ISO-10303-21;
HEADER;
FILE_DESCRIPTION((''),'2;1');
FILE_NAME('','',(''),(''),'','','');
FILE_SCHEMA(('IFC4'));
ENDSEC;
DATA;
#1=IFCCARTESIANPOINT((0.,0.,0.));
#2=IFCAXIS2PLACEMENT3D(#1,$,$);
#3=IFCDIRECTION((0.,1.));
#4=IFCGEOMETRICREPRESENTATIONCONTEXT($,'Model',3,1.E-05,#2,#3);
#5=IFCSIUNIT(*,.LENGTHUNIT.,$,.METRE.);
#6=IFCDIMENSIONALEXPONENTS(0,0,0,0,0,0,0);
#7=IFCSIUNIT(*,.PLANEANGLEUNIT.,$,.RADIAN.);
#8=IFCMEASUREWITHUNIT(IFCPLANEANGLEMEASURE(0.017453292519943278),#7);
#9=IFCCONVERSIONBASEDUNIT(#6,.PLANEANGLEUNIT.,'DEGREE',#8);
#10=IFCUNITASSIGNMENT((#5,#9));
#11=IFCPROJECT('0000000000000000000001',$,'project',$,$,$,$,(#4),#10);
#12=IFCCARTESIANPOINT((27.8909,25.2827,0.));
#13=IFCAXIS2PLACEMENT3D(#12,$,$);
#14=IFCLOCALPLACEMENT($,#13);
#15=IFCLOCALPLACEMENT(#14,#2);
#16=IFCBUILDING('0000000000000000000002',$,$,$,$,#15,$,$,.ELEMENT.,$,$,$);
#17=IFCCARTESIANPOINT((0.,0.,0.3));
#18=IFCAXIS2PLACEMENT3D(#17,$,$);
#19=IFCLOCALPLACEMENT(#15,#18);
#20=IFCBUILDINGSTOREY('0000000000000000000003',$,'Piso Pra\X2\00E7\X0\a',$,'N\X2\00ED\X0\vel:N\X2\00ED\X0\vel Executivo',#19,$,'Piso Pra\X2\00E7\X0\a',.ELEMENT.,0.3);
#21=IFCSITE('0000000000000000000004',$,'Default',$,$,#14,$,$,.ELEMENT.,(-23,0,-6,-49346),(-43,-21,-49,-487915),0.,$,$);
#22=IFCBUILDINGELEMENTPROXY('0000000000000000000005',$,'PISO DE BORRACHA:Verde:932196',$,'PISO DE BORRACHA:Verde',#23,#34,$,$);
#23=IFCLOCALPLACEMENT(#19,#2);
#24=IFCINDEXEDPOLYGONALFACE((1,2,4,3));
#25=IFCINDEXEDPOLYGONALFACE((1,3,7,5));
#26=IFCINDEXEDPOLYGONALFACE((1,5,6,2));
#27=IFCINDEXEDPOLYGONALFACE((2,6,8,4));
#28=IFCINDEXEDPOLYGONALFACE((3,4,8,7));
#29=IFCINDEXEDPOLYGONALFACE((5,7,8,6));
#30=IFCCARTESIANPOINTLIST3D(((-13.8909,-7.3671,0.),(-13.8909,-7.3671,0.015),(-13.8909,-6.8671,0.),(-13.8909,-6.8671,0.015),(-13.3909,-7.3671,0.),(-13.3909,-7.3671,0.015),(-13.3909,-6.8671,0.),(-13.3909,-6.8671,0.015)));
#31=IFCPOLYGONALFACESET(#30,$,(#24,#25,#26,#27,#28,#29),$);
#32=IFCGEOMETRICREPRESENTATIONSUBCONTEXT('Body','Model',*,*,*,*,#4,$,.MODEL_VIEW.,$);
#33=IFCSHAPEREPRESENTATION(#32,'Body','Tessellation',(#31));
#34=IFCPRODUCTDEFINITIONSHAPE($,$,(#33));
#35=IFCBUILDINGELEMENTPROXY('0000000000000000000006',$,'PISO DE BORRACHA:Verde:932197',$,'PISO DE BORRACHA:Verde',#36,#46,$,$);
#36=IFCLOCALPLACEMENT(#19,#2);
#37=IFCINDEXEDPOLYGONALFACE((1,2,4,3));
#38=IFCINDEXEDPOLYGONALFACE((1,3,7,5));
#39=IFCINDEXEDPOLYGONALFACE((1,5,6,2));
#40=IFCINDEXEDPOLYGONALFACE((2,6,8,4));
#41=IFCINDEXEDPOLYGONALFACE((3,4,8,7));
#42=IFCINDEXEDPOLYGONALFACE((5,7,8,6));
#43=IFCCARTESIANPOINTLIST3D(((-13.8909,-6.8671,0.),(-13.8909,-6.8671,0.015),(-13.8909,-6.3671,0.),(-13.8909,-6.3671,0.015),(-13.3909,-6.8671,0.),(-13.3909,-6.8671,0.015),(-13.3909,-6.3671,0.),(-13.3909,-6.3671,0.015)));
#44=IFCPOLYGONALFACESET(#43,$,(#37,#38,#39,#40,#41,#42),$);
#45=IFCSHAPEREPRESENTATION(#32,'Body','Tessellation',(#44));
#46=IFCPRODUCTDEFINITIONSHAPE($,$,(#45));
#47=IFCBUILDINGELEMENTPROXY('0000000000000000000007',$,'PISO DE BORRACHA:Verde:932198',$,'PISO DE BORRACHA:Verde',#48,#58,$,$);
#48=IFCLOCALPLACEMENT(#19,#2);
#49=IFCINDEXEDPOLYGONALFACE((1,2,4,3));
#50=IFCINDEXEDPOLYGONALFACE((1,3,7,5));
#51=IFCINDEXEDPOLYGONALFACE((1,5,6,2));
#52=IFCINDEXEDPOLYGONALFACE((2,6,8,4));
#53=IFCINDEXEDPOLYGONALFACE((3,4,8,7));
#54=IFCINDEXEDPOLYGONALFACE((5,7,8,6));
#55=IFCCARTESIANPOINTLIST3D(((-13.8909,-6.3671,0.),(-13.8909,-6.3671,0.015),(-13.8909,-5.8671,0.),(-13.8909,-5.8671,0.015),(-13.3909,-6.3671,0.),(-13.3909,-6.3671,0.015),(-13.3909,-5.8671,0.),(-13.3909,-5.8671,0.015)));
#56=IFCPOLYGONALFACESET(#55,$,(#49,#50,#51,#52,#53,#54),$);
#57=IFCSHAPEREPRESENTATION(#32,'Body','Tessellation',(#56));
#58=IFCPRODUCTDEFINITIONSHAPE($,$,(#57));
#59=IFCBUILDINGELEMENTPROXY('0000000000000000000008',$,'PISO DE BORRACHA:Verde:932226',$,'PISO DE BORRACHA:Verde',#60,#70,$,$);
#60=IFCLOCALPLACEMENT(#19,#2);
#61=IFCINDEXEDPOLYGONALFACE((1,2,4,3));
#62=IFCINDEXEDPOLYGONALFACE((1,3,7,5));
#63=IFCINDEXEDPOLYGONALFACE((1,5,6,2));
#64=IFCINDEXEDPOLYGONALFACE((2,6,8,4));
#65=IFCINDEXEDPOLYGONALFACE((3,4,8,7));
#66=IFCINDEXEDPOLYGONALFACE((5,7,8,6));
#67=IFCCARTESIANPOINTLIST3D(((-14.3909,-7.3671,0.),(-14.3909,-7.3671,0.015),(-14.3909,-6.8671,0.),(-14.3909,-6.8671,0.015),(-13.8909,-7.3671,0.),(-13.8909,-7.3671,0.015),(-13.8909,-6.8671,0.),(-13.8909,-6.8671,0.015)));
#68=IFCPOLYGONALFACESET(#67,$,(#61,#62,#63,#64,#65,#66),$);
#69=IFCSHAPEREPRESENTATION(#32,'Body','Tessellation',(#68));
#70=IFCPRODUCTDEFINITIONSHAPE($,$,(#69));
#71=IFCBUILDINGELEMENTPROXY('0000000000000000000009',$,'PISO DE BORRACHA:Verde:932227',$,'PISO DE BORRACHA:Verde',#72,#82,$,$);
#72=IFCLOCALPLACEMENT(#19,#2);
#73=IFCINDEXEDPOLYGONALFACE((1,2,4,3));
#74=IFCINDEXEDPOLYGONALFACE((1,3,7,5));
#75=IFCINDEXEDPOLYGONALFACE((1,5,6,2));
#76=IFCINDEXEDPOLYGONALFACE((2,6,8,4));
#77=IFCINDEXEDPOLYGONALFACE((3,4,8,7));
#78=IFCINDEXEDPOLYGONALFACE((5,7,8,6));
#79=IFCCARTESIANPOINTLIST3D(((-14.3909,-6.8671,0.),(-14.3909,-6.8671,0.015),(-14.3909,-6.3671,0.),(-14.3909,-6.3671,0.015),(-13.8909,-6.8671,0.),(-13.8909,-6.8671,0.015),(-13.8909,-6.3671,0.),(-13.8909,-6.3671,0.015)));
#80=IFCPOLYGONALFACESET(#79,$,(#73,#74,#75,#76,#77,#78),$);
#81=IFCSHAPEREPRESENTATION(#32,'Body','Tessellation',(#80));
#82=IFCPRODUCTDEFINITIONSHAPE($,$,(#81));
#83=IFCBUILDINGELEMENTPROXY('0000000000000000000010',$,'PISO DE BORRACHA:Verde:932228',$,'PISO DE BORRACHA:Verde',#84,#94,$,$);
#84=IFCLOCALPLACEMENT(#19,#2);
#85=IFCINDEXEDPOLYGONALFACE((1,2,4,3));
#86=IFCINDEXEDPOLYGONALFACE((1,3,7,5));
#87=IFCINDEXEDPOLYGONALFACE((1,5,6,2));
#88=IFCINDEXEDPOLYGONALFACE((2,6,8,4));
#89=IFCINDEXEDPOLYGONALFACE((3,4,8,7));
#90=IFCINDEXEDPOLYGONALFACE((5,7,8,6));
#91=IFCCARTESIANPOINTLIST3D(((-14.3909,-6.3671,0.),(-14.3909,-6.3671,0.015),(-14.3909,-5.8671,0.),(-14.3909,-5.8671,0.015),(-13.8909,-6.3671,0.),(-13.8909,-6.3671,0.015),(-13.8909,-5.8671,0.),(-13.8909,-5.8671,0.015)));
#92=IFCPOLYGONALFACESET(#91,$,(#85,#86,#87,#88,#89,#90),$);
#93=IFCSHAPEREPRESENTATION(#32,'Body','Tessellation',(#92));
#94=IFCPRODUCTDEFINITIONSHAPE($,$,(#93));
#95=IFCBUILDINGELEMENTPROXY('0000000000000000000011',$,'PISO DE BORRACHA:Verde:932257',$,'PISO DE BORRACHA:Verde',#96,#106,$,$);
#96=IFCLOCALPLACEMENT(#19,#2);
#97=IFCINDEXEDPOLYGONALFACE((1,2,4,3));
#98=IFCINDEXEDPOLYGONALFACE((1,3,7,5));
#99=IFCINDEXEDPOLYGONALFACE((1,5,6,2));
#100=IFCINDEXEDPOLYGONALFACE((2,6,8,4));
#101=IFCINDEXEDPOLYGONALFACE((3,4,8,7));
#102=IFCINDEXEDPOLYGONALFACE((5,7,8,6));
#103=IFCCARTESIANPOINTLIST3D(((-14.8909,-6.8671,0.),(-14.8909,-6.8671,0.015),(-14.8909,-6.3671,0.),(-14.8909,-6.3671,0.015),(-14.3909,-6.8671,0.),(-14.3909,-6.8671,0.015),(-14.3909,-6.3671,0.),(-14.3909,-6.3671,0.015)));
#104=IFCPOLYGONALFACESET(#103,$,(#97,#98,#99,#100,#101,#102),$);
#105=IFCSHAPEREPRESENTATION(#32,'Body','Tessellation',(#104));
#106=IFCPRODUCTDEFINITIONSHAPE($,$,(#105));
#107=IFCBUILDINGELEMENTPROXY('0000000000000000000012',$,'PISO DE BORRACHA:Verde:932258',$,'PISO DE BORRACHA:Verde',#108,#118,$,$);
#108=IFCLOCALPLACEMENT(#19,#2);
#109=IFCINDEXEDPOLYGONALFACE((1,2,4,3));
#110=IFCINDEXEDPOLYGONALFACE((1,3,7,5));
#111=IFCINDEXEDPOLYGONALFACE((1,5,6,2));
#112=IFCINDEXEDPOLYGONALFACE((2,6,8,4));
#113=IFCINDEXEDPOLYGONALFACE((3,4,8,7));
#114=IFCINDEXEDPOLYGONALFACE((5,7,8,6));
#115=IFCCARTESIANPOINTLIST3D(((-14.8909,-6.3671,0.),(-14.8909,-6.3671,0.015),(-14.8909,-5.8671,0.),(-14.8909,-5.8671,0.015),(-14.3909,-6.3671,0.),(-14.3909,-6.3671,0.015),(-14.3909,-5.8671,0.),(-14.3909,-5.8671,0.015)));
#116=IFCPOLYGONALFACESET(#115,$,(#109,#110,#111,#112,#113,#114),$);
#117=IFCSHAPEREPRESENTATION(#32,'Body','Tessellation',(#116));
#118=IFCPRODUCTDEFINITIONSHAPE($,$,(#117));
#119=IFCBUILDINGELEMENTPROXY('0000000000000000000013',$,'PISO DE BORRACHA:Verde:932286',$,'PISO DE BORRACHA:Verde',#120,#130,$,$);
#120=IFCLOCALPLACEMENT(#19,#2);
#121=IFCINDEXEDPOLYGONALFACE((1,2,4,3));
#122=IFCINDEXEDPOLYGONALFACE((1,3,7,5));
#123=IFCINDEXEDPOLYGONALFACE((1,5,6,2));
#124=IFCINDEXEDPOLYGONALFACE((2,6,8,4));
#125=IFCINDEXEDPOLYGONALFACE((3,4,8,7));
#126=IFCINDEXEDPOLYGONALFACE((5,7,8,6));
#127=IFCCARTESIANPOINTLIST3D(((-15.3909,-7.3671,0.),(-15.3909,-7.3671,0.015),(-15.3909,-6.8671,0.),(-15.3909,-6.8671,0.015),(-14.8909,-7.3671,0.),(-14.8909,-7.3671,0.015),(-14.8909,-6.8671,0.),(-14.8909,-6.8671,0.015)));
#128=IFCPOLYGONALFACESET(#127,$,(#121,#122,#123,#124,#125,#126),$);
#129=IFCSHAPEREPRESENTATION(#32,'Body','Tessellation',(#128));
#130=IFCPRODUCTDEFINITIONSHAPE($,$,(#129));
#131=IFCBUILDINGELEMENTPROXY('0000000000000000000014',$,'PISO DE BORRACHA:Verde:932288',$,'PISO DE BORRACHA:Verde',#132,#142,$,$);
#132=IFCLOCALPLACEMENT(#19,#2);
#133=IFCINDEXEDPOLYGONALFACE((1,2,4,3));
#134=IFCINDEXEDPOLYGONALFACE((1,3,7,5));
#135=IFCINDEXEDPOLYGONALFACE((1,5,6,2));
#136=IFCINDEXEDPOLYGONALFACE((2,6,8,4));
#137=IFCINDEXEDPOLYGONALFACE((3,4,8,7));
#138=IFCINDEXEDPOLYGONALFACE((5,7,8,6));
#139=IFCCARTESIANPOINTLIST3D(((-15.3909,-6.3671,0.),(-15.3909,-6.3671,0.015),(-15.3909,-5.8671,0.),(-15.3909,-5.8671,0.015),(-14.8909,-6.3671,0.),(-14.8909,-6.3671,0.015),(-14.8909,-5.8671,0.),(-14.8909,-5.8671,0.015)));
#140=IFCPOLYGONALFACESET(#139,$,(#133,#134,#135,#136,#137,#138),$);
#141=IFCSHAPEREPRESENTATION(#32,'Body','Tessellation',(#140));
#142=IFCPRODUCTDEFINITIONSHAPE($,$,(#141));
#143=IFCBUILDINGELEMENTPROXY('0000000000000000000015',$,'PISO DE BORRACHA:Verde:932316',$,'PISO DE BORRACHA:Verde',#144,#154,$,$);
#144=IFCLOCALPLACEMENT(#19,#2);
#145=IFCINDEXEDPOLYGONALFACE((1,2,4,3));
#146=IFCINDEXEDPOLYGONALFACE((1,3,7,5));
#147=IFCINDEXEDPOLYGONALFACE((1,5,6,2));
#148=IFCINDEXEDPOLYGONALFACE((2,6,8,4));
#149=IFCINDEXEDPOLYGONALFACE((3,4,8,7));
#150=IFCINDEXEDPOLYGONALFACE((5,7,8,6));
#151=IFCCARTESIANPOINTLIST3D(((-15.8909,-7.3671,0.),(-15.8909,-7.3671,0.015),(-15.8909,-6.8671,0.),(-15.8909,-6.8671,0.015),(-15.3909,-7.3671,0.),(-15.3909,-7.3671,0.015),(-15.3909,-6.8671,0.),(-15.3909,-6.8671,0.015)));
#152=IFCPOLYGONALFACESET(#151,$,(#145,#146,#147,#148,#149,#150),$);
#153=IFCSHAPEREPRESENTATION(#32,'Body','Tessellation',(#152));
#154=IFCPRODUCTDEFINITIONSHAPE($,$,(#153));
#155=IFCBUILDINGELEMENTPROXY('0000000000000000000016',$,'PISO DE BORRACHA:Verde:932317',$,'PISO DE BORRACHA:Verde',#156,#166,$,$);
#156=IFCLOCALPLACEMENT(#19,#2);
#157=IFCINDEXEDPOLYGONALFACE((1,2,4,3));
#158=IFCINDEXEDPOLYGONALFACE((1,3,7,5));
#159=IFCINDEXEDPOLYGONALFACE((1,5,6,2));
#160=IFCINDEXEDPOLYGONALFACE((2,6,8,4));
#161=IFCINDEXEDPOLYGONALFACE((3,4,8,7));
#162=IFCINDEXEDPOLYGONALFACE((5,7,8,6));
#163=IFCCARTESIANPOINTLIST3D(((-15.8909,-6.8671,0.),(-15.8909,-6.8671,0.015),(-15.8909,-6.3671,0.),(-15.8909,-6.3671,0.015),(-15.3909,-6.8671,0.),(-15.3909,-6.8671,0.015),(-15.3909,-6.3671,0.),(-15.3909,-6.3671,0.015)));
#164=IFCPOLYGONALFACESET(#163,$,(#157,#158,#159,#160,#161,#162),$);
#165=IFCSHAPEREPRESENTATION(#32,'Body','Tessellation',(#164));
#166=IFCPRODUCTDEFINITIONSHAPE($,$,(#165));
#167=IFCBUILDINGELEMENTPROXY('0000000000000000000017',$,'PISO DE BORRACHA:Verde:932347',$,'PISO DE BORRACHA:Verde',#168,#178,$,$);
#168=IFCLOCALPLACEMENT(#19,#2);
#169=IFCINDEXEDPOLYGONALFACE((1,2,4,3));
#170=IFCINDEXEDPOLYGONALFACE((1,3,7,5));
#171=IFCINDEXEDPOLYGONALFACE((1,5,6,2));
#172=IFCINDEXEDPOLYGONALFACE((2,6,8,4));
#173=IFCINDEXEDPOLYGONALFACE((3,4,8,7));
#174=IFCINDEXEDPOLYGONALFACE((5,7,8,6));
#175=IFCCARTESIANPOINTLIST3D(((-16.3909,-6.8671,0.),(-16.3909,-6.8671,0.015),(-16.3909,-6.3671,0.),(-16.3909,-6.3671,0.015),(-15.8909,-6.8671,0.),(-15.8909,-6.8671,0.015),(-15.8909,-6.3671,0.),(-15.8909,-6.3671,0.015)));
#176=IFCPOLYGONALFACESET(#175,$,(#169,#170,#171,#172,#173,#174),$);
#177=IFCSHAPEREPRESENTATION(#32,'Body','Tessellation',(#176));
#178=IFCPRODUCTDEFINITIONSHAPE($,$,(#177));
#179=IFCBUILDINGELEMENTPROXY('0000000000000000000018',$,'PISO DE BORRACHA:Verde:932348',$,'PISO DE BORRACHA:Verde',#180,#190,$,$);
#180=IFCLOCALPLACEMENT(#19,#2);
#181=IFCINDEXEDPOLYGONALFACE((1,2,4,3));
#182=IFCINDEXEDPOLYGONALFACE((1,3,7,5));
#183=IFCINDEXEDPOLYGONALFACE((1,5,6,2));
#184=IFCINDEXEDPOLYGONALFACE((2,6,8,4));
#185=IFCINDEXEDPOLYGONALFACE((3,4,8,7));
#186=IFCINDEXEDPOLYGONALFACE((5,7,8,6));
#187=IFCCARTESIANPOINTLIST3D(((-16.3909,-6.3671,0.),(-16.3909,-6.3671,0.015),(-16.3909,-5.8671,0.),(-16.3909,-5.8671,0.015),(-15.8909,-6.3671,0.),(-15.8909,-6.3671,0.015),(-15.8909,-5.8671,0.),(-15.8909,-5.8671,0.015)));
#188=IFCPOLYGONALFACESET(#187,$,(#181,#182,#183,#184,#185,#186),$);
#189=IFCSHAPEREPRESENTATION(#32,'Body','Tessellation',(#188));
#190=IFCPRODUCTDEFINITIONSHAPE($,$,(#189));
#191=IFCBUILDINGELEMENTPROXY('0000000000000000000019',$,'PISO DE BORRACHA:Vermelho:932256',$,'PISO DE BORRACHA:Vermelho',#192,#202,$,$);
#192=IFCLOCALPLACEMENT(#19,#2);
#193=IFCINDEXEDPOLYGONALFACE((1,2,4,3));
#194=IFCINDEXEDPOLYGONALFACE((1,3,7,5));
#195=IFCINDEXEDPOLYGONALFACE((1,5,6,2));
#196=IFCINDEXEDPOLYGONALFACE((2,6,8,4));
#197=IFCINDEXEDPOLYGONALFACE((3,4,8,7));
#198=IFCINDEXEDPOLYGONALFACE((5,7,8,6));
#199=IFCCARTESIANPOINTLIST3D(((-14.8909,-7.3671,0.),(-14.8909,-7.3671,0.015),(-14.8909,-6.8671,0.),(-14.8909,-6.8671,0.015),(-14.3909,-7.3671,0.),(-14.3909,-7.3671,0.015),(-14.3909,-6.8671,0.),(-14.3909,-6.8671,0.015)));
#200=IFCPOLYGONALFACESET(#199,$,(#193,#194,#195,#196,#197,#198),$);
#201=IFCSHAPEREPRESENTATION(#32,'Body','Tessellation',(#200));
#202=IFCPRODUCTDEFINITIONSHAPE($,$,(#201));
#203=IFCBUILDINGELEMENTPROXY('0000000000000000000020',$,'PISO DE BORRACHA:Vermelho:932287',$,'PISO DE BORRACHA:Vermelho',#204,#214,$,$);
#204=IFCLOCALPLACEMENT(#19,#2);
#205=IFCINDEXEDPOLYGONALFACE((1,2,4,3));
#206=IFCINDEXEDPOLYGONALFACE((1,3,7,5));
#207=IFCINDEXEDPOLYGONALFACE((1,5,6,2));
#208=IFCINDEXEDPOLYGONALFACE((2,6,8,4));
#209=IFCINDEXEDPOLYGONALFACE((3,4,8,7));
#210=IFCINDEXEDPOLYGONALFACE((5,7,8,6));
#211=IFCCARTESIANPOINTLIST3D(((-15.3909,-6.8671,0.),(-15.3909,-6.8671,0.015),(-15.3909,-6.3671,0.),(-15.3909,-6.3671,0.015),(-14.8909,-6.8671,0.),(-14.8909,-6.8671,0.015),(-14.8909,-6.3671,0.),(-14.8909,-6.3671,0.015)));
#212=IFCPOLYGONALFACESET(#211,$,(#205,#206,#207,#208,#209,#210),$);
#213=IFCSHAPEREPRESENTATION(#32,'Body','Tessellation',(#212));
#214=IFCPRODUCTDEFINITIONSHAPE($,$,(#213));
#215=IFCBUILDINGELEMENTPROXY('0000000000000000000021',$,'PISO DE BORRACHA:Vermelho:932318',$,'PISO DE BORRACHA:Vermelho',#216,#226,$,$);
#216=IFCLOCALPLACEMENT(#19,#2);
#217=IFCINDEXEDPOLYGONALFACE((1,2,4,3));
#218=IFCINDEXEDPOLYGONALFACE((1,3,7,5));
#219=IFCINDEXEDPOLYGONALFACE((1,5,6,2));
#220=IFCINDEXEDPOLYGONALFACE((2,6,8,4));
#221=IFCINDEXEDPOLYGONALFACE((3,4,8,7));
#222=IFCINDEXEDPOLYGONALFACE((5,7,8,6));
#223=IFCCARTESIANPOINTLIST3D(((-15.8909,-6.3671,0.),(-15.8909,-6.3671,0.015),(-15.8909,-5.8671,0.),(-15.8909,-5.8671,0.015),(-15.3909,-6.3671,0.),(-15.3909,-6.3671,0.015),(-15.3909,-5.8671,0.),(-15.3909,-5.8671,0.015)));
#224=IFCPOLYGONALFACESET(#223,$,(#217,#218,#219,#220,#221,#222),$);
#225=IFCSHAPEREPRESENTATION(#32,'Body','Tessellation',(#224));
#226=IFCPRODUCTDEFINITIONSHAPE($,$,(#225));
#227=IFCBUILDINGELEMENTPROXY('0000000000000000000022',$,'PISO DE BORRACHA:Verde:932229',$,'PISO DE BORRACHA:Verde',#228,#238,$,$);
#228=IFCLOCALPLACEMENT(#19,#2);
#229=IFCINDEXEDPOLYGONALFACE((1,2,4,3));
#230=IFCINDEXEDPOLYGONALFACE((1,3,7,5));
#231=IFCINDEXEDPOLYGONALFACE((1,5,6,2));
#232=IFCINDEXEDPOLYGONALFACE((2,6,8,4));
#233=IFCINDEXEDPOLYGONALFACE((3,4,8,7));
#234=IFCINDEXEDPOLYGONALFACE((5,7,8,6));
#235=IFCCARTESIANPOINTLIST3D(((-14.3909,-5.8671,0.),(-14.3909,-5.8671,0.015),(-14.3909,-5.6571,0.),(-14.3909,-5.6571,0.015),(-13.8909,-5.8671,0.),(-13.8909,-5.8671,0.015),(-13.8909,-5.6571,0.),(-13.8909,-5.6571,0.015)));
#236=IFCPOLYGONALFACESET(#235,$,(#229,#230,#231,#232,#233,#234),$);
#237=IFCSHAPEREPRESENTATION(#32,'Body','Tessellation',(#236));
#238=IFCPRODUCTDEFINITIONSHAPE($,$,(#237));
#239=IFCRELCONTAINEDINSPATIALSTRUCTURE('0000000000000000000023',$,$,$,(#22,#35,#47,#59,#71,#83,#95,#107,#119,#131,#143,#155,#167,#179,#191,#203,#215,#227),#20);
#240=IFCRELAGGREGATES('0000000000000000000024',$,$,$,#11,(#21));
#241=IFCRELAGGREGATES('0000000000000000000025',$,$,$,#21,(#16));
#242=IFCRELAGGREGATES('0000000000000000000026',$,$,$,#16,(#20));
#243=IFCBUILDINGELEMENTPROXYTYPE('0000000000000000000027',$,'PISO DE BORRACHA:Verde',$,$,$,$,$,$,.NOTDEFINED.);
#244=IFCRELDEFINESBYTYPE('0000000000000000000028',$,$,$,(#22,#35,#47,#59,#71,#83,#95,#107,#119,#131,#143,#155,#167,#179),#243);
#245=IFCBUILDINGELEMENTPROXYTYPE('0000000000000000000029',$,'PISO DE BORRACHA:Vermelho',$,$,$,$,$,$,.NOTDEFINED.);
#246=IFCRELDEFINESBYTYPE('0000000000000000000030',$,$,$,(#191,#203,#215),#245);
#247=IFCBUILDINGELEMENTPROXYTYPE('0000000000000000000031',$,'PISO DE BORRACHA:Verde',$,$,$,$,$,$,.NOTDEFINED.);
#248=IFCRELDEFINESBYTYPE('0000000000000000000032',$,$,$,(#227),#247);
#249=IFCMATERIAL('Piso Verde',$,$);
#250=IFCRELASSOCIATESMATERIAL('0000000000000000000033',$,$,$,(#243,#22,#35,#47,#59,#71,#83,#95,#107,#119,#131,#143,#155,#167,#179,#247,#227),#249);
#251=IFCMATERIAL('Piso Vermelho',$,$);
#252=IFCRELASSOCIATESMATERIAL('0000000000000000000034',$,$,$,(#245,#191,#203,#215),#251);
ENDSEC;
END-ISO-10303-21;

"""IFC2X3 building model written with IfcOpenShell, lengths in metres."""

from ifc_helpers import new_model, entity, si_unit, converted_unit, direction, frame, frame_2d, origin, origin_2d_with_axis, place, context, subcontext, project, spatial, rectangle, extrude, source, transform, mapped, material, type_object, type_shapes, element, save


model = new_model("IFC2X3")

# Units and contexts
model_context = context("Model", 3, precision=1e-05, world=origin(), true_north=direction((0.0, 1.0)))
body_context = subcontext(model_context, "Body", "Model", "MODEL_VIEW")
ifc_project = project(units=[si_unit("LENGTHUNIT", "METRE"), converted_unit("PLANEANGLEUNIT", "DEGREE", entity("IfcPlaneAngleMeasure", 0.017453292519943278), si_unit("PLANEANGLEUNIT", "RADIAN"), dimensions=[0, 0, 0, 0, 0, 0, 0])], contexts=[model_context])

# Site, building, storey
site_placement = place(None, frame((27.8909, 25.2827, 0.0)))
site = spatial("IfcSite", under=ifc_project, at=site_placement, Name="Default", CompositionType="ELEMENT", RefLatitude=(-23, 0, -6, -49346), RefLongitude=(-43, -21, -49, -487915), RefElevation=0.0)
building_placement = place(site_placement, origin())
building = spatial("IfcBuilding", under=site, at=building_placement, CompositionType="ELEMENT")
storey_placement = place(building_placement, frame((0.0, 0.0, 0.3)))
storey = spatial("IfcBuildingStorey", under=building, at=storey_placement, Name="Piso Praça", ObjectType="Nível:Nível Executivo", LongName="Piso Praça", CompositionType="ELEMENT", Elevation=0.3)

# Building element proxies
ifc_material_1 = material(Name="Piso Verde")
building_element_proxy_type_1 = type_object("IfcBuildingElementProxyType", Name="PISO DE BORRACHA:Verde", PredefinedType="NOTDEFINED", material=ifc_material_1)
shared_shape_1 = source(origin(), body_context, "Body", "SweptSolid", [
    extrude(rectangle(XDim=0.5, YDim=0.5, at=origin_2d_with_axis()), frame((0.25, 0.25, 0.0), z_axis=(0.0, 0.0, 1.0), x_axis=(-1.0, 0.0, 0.0)), (0.0, 0.0, 1.0), 0.015),
])
type_shapes(building_element_proxy_type_1, [shared_shape_1])
for number, where, z_axis, x_axis, name in (
    (1, (-13.8909, -6.8671, 0.0), (0.0, 0.0, 1.0), (0.0, -1.0, 0.0), "PISO DE BORRACHA:Verde:932196"),
    (2, (-13.8909, -6.3671, 0.0), (0.0, 0.0, 1.0), (0.0, -1.0, 0.0), "PISO DE BORRACHA:Verde:932197"),
    (3, (-13.8909, -5.8671, 0.0), (0.0, 0.0, 1.0), (0.0, -1.0, 0.0), "PISO DE BORRACHA:Verde:932198"),
    (4, (-14.3909, -6.8671, 0.0), (0.0, 0.0, 1.0), (0.0, -1.0, 0.0), "PISO DE BORRACHA:Verde:932226"),
    (5, (-14.3909, -6.3671, 0.0), (0.0, 0.0, 1.0), (0.0, -1.0, 0.0), "PISO DE BORRACHA:Verde:932227"),
    (6, (-14.3909, -5.8671, 0.0), (0.0, 0.0, 1.0), (0.0, -1.0, 0.0), "PISO DE BORRACHA:Verde:932228"),
    (7, (-14.8909, -6.3671, 0.0), (0.0, 0.0, 1.0), (0.0, -1.0, 0.0), "PISO DE BORRACHA:Verde:932257"),
    (8, (-14.8909, -5.8671, 0.0), (0.0, 0.0, 1.0), (0.0, -1.0, 0.0), "PISO DE BORRACHA:Verde:932258"),
    (9, (-15.3909, -6.8671, 0.0), (0.0, 0.0, 1.0), (0.0, -1.0, 0.0), "PISO DE BORRACHA:Verde:932286"),
    (10, (-15.3909, -5.8671, 0.0), (0.0, 0.0, 1.0), (0.0, -1.0, 0.0), "PISO DE BORRACHA:Verde:932288"),
    (11, (-15.8909, -6.8671, 0.0), (0.0, 0.0, 1.0), (0.0, -1.0, 0.0), "PISO DE BORRACHA:Verde:932316"),
    (12, (-15.8909, -6.3671, 0.0), (0.0, 0.0, 1.0), (0.0, -1.0, 0.0), "PISO DE BORRACHA:Verde:932317"),
    (13, (-16.3909, -6.3671, 0.0), (0.0, 0.0, 1.0), (0.0, -1.0, 0.0), "PISO DE BORRACHA:Verde:932347"),
    (14, (-16.3909, -5.8671, 0.0), (0.0, 0.0, 1.0), (0.0, -1.0, 0.0), "PISO DE BORRACHA:Verde:932348"),
):
    element("IfcBuildingElementProxy", number, at=place(storey_placement, frame(where, z_axis=z_axis, x_axis=x_axis)), inside=storey, type_object=building_element_proxy_type_1, material=ifc_material_1, Name=name, ObjectType="PISO DE BORRACHA:Verde", context=body_context, shape_type="MappedRepresentation", body=[
        mapped(shared_shape_1, transform((0.0, 0.0, 0.0), scale=1.0)),
    ])
ifc_material_2 = material(Name="Piso Vermelho")
building_element_proxy_type_2 = type_object("IfcBuildingElementProxyType", Name="PISO DE BORRACHA:Vermelho", PredefinedType="NOTDEFINED", material=ifc_material_2)
shared_shape_2 = source(origin(), body_context, "Body", "SweptSolid", [
    extrude(rectangle(XDim=0.5, YDim=0.5, at=origin_2d_with_axis()), frame((0.25, 0.25, 0.0), z_axis=(0.0, 0.0, 1.0), x_axis=(-1.0, 0.0, 0.0)), (0.0, 0.0, 1.0), 0.015),
])
type_shapes(building_element_proxy_type_2, [shared_shape_2])
for number, where, z_axis, x_axis, name in (
    (15, (-14.8909, -6.8671, 0.0), (0.0, 0.0, 1.0), (0.0, -1.0, 0.0), "PISO DE BORRACHA:Vermelho:932256"),
    (16, (-15.3909, -6.3671, 0.0), (0.0, 0.0, 1.0), (0.0, -1.0, 0.0), "PISO DE BORRACHA:Vermelho:932287"),
    (17, (-15.8909, -5.8671, 0.0), (0.0, 0.0, 1.0), (0.0, -1.0, 0.0), "PISO DE BORRACHA:Vermelho:932318"),
):
    element("IfcBuildingElementProxy", number, at=place(storey_placement, frame(where, z_axis=z_axis, x_axis=x_axis)), inside=storey, type_object=building_element_proxy_type_2, material=ifc_material_2, Name=name, ObjectType="PISO DE BORRACHA:Vermelho", context=body_context, shape_type="MappedRepresentation", body=[
        mapped(shared_shape_2, transform((0.0, 0.0, 0.0), scale=1.0)),
    ])
building_element_proxy_type_3 = type_object("IfcBuildingElementProxyType", Name="PISO DE BORRACHA:Verde", PredefinedType="NOTDEFINED", material=ifc_material_1)
shared_shape_3 = source(origin(), body_context, "Body", "SweptSolid", [
    extrude(rectangle(XDim=0.21, YDim=0.5, at=frame_2d((0.0, 0.0), x_axis=(1.0, 0.0))), frame((0.105, 0.25, 0.0), z_axis=(0.0, 0.0, 1.0), x_axis=(-1.0, 0.0, 0.0)), (0.0, 0.0, 1.0), 0.015),
])
type_shapes(building_element_proxy_type_3, [shared_shape_3])
for number, where, z_axis, x_axis, name in (
    (18, (-14.3909, -5.6571, 0.0), (0.0, 0.0, 1.0), (0.0, -1.0, 0.0), "PISO DE BORRACHA:Verde:932229"),
):
    element("IfcBuildingElementProxy", number, at=place(storey_placement, frame(where, z_axis=z_axis, x_axis=x_axis)), inside=storey, type_object=building_element_proxy_type_3, material=ifc_material_1, Name=name, ObjectType="PISO DE BORRACHA:Verde", context=body_context, shape_type="MappedRepresentation", body=[
        mapped(shared_shape_3, transform((0.0, 0.0, 0.0), scale=1.0)),
    ])

save(model, "model.ifc")
